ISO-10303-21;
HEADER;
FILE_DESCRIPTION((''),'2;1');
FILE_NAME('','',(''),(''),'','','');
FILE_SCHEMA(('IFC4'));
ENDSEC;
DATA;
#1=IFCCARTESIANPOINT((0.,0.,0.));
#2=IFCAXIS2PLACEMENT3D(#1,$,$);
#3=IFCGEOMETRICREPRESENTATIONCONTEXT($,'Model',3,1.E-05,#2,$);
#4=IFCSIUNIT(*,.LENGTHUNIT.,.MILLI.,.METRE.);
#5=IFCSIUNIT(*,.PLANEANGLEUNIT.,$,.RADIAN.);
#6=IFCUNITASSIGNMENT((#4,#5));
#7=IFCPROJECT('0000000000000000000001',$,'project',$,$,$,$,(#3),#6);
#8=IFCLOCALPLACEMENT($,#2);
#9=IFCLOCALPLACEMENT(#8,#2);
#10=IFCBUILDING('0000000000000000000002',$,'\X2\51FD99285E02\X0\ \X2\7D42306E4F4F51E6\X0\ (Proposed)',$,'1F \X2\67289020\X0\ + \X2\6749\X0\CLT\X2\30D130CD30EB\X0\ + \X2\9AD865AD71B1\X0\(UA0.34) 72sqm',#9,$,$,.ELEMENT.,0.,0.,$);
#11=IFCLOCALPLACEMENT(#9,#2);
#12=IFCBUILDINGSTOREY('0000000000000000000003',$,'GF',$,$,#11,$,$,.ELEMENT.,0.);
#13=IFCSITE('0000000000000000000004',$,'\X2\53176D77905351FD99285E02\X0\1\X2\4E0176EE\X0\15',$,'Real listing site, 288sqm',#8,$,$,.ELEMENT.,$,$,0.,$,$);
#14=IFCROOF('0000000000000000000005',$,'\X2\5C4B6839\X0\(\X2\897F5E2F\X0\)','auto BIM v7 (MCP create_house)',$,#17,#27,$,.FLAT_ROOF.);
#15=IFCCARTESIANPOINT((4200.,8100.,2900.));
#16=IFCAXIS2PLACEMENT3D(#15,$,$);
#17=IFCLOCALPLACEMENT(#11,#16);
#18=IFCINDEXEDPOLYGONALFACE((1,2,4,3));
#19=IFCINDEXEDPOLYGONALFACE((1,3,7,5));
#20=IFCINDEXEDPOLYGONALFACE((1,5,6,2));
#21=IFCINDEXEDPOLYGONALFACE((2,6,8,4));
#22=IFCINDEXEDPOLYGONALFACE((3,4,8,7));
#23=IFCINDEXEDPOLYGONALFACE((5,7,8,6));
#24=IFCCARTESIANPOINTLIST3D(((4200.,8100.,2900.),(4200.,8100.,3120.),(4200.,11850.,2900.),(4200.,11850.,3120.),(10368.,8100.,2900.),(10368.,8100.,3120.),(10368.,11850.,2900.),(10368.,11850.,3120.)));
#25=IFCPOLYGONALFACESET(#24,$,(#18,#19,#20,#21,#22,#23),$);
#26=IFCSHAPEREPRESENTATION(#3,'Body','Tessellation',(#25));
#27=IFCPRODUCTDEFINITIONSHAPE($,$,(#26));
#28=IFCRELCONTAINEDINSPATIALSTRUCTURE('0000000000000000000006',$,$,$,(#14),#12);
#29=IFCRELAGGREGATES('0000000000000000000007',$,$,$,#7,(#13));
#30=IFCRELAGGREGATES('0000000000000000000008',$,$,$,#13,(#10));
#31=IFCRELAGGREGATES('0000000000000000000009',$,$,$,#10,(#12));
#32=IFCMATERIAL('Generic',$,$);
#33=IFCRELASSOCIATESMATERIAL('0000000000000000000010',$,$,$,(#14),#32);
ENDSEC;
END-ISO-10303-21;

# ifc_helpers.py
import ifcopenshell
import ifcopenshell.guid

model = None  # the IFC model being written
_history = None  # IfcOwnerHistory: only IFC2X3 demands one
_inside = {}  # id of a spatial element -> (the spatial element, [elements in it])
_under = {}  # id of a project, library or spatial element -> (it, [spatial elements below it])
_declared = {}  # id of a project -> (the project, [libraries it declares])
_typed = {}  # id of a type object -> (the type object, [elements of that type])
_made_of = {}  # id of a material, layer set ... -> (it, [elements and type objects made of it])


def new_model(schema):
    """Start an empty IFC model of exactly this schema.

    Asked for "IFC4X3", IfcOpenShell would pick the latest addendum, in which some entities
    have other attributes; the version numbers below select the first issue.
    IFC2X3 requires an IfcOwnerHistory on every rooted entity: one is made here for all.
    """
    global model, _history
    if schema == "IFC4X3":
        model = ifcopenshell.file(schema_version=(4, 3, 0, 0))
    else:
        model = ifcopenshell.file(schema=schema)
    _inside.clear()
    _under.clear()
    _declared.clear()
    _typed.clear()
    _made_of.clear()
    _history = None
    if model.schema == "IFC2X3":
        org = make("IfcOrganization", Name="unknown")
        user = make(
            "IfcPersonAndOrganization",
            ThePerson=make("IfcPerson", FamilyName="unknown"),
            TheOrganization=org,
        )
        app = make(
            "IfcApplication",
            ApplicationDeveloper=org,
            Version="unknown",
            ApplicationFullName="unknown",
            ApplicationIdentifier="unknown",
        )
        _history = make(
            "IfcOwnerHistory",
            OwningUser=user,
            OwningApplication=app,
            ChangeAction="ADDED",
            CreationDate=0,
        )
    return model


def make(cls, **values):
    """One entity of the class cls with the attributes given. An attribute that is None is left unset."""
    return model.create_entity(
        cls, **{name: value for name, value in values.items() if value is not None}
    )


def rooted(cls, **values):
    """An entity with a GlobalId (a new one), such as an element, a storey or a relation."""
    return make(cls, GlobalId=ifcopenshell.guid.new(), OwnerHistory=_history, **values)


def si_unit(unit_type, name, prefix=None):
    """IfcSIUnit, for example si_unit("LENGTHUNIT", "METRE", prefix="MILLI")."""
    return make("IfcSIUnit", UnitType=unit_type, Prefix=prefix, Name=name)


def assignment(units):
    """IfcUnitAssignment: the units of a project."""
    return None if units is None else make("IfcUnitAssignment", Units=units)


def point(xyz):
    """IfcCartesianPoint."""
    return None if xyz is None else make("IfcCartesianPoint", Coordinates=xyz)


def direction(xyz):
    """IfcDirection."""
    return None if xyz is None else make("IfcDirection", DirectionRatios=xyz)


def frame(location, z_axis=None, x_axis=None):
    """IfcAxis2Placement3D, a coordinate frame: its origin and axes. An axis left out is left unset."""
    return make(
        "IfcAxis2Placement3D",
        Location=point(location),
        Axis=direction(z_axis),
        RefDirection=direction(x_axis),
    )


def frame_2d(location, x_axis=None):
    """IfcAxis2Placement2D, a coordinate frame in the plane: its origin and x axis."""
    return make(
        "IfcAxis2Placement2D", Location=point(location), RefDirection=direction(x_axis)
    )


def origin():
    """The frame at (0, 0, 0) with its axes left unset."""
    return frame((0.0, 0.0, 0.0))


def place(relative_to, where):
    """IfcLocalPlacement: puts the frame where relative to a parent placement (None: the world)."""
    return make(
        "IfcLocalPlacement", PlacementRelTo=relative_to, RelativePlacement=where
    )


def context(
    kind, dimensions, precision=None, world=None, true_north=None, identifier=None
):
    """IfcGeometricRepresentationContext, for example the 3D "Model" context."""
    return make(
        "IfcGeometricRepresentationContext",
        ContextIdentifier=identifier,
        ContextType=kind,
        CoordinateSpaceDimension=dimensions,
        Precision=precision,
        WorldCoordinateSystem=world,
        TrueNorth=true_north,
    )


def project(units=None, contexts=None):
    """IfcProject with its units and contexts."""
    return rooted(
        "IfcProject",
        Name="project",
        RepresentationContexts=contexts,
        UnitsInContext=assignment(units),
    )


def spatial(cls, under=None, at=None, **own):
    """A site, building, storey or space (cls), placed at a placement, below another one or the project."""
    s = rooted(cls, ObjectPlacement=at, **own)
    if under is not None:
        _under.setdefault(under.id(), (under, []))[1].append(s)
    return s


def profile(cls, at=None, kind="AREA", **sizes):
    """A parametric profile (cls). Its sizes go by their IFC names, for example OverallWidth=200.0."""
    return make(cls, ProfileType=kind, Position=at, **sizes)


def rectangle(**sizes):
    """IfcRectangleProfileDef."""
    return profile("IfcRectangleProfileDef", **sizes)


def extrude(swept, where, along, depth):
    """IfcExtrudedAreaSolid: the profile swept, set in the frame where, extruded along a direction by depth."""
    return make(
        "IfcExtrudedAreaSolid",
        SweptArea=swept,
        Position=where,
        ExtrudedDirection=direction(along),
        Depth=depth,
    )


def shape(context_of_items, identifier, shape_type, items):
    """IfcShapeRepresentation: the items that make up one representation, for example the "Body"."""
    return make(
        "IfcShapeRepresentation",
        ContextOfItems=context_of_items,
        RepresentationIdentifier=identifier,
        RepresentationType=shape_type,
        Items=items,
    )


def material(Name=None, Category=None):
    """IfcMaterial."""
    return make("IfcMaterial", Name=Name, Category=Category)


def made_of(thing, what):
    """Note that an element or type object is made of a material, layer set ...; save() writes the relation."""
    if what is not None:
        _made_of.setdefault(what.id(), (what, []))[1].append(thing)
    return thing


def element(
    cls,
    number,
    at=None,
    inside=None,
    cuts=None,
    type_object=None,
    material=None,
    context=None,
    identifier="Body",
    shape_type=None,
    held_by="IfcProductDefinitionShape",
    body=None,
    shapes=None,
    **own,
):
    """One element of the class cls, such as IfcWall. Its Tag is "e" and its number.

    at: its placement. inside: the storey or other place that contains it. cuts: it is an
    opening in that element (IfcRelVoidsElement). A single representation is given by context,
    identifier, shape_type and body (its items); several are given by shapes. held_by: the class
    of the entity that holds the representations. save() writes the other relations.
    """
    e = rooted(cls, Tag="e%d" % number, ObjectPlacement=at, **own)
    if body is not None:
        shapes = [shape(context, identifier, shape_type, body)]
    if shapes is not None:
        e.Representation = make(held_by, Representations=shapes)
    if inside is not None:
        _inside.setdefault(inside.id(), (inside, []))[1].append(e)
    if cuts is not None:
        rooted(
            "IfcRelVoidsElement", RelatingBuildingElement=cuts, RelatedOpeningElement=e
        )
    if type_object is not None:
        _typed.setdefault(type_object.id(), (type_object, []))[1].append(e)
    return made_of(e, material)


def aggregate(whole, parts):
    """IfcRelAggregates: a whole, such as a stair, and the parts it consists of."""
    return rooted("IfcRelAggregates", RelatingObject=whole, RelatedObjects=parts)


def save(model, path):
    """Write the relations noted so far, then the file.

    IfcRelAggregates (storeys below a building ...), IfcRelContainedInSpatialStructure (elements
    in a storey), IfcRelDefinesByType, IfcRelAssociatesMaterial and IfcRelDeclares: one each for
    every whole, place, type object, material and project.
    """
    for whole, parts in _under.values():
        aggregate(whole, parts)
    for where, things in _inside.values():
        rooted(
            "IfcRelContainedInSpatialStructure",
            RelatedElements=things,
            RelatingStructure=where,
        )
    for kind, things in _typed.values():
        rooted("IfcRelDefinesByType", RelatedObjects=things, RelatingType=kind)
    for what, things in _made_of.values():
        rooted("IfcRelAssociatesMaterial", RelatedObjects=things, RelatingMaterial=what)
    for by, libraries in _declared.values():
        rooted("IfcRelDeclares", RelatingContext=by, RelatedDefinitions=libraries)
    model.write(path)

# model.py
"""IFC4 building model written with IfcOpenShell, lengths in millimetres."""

from ifc_helpers import new_model, si_unit, frame, frame_2d, origin, place, context, project, spatial, rectangle, extrude, material, element, save


model = new_model("IFC4")

# Units and contexts
model_context = context("Model", 3, precision=1e-05, world=origin())
ifc_project = project(units=[si_unit("LENGTHUNIT", "METRE", prefix="MILLI"), si_unit("PLANEANGLEUNIT", "RADIAN")], contexts=[model_context])

# Site, building, storey
site_placement = place(None, origin())
site = spatial("IfcSite", under=ifc_project, at=site_placement, Name="北海道函館市1丁目15", ObjectType="Real listing site, 288sqm", CompositionType="ELEMENT", RefElevation=0.0)
building_placement = place(site_placement, origin())
building = spatial("IfcBuilding", under=site, at=building_placement, Name="函館市 終の住処 (Proposed)", ObjectType="1F 木造 + 杉CLTパネル + 高断熱(UA0.34) 72sqm", CompositionType="ELEMENT", ElevationOfRefHeight=0.0, ElevationOfTerrain=0.0)
storey_placement = place(building_placement, origin())
storey = spatial("IfcBuildingStorey", under=building, at=storey_placement, Name="GF", CompositionType="ELEMENT", Elevation=0.0)

# Shared definitions
ifc_material = material(Name="Generic")

# Roof
roof_1_placement = place(storey_placement, frame((4200.0, 8100.0, 2900.0)))
element("IfcRoof", 1, at=roof_1_placement, inside=storey, material=ifc_material, Name="屋根(西帯)", Description="auto BIM v7 (MCP create_house)", PredefinedType="FLAT_ROOF", context=model_context, shape_type="SweptSolid", body=[
    extrude(rectangle(XDim=6168.0, YDim=3750.0, at=frame_2d((3084.0, 1875.0))), frame((4200.0, 8100.0, 2900.0)), (0.0, 0.0, 1.0), 220.0),
])

save(model, "model.ifc")
